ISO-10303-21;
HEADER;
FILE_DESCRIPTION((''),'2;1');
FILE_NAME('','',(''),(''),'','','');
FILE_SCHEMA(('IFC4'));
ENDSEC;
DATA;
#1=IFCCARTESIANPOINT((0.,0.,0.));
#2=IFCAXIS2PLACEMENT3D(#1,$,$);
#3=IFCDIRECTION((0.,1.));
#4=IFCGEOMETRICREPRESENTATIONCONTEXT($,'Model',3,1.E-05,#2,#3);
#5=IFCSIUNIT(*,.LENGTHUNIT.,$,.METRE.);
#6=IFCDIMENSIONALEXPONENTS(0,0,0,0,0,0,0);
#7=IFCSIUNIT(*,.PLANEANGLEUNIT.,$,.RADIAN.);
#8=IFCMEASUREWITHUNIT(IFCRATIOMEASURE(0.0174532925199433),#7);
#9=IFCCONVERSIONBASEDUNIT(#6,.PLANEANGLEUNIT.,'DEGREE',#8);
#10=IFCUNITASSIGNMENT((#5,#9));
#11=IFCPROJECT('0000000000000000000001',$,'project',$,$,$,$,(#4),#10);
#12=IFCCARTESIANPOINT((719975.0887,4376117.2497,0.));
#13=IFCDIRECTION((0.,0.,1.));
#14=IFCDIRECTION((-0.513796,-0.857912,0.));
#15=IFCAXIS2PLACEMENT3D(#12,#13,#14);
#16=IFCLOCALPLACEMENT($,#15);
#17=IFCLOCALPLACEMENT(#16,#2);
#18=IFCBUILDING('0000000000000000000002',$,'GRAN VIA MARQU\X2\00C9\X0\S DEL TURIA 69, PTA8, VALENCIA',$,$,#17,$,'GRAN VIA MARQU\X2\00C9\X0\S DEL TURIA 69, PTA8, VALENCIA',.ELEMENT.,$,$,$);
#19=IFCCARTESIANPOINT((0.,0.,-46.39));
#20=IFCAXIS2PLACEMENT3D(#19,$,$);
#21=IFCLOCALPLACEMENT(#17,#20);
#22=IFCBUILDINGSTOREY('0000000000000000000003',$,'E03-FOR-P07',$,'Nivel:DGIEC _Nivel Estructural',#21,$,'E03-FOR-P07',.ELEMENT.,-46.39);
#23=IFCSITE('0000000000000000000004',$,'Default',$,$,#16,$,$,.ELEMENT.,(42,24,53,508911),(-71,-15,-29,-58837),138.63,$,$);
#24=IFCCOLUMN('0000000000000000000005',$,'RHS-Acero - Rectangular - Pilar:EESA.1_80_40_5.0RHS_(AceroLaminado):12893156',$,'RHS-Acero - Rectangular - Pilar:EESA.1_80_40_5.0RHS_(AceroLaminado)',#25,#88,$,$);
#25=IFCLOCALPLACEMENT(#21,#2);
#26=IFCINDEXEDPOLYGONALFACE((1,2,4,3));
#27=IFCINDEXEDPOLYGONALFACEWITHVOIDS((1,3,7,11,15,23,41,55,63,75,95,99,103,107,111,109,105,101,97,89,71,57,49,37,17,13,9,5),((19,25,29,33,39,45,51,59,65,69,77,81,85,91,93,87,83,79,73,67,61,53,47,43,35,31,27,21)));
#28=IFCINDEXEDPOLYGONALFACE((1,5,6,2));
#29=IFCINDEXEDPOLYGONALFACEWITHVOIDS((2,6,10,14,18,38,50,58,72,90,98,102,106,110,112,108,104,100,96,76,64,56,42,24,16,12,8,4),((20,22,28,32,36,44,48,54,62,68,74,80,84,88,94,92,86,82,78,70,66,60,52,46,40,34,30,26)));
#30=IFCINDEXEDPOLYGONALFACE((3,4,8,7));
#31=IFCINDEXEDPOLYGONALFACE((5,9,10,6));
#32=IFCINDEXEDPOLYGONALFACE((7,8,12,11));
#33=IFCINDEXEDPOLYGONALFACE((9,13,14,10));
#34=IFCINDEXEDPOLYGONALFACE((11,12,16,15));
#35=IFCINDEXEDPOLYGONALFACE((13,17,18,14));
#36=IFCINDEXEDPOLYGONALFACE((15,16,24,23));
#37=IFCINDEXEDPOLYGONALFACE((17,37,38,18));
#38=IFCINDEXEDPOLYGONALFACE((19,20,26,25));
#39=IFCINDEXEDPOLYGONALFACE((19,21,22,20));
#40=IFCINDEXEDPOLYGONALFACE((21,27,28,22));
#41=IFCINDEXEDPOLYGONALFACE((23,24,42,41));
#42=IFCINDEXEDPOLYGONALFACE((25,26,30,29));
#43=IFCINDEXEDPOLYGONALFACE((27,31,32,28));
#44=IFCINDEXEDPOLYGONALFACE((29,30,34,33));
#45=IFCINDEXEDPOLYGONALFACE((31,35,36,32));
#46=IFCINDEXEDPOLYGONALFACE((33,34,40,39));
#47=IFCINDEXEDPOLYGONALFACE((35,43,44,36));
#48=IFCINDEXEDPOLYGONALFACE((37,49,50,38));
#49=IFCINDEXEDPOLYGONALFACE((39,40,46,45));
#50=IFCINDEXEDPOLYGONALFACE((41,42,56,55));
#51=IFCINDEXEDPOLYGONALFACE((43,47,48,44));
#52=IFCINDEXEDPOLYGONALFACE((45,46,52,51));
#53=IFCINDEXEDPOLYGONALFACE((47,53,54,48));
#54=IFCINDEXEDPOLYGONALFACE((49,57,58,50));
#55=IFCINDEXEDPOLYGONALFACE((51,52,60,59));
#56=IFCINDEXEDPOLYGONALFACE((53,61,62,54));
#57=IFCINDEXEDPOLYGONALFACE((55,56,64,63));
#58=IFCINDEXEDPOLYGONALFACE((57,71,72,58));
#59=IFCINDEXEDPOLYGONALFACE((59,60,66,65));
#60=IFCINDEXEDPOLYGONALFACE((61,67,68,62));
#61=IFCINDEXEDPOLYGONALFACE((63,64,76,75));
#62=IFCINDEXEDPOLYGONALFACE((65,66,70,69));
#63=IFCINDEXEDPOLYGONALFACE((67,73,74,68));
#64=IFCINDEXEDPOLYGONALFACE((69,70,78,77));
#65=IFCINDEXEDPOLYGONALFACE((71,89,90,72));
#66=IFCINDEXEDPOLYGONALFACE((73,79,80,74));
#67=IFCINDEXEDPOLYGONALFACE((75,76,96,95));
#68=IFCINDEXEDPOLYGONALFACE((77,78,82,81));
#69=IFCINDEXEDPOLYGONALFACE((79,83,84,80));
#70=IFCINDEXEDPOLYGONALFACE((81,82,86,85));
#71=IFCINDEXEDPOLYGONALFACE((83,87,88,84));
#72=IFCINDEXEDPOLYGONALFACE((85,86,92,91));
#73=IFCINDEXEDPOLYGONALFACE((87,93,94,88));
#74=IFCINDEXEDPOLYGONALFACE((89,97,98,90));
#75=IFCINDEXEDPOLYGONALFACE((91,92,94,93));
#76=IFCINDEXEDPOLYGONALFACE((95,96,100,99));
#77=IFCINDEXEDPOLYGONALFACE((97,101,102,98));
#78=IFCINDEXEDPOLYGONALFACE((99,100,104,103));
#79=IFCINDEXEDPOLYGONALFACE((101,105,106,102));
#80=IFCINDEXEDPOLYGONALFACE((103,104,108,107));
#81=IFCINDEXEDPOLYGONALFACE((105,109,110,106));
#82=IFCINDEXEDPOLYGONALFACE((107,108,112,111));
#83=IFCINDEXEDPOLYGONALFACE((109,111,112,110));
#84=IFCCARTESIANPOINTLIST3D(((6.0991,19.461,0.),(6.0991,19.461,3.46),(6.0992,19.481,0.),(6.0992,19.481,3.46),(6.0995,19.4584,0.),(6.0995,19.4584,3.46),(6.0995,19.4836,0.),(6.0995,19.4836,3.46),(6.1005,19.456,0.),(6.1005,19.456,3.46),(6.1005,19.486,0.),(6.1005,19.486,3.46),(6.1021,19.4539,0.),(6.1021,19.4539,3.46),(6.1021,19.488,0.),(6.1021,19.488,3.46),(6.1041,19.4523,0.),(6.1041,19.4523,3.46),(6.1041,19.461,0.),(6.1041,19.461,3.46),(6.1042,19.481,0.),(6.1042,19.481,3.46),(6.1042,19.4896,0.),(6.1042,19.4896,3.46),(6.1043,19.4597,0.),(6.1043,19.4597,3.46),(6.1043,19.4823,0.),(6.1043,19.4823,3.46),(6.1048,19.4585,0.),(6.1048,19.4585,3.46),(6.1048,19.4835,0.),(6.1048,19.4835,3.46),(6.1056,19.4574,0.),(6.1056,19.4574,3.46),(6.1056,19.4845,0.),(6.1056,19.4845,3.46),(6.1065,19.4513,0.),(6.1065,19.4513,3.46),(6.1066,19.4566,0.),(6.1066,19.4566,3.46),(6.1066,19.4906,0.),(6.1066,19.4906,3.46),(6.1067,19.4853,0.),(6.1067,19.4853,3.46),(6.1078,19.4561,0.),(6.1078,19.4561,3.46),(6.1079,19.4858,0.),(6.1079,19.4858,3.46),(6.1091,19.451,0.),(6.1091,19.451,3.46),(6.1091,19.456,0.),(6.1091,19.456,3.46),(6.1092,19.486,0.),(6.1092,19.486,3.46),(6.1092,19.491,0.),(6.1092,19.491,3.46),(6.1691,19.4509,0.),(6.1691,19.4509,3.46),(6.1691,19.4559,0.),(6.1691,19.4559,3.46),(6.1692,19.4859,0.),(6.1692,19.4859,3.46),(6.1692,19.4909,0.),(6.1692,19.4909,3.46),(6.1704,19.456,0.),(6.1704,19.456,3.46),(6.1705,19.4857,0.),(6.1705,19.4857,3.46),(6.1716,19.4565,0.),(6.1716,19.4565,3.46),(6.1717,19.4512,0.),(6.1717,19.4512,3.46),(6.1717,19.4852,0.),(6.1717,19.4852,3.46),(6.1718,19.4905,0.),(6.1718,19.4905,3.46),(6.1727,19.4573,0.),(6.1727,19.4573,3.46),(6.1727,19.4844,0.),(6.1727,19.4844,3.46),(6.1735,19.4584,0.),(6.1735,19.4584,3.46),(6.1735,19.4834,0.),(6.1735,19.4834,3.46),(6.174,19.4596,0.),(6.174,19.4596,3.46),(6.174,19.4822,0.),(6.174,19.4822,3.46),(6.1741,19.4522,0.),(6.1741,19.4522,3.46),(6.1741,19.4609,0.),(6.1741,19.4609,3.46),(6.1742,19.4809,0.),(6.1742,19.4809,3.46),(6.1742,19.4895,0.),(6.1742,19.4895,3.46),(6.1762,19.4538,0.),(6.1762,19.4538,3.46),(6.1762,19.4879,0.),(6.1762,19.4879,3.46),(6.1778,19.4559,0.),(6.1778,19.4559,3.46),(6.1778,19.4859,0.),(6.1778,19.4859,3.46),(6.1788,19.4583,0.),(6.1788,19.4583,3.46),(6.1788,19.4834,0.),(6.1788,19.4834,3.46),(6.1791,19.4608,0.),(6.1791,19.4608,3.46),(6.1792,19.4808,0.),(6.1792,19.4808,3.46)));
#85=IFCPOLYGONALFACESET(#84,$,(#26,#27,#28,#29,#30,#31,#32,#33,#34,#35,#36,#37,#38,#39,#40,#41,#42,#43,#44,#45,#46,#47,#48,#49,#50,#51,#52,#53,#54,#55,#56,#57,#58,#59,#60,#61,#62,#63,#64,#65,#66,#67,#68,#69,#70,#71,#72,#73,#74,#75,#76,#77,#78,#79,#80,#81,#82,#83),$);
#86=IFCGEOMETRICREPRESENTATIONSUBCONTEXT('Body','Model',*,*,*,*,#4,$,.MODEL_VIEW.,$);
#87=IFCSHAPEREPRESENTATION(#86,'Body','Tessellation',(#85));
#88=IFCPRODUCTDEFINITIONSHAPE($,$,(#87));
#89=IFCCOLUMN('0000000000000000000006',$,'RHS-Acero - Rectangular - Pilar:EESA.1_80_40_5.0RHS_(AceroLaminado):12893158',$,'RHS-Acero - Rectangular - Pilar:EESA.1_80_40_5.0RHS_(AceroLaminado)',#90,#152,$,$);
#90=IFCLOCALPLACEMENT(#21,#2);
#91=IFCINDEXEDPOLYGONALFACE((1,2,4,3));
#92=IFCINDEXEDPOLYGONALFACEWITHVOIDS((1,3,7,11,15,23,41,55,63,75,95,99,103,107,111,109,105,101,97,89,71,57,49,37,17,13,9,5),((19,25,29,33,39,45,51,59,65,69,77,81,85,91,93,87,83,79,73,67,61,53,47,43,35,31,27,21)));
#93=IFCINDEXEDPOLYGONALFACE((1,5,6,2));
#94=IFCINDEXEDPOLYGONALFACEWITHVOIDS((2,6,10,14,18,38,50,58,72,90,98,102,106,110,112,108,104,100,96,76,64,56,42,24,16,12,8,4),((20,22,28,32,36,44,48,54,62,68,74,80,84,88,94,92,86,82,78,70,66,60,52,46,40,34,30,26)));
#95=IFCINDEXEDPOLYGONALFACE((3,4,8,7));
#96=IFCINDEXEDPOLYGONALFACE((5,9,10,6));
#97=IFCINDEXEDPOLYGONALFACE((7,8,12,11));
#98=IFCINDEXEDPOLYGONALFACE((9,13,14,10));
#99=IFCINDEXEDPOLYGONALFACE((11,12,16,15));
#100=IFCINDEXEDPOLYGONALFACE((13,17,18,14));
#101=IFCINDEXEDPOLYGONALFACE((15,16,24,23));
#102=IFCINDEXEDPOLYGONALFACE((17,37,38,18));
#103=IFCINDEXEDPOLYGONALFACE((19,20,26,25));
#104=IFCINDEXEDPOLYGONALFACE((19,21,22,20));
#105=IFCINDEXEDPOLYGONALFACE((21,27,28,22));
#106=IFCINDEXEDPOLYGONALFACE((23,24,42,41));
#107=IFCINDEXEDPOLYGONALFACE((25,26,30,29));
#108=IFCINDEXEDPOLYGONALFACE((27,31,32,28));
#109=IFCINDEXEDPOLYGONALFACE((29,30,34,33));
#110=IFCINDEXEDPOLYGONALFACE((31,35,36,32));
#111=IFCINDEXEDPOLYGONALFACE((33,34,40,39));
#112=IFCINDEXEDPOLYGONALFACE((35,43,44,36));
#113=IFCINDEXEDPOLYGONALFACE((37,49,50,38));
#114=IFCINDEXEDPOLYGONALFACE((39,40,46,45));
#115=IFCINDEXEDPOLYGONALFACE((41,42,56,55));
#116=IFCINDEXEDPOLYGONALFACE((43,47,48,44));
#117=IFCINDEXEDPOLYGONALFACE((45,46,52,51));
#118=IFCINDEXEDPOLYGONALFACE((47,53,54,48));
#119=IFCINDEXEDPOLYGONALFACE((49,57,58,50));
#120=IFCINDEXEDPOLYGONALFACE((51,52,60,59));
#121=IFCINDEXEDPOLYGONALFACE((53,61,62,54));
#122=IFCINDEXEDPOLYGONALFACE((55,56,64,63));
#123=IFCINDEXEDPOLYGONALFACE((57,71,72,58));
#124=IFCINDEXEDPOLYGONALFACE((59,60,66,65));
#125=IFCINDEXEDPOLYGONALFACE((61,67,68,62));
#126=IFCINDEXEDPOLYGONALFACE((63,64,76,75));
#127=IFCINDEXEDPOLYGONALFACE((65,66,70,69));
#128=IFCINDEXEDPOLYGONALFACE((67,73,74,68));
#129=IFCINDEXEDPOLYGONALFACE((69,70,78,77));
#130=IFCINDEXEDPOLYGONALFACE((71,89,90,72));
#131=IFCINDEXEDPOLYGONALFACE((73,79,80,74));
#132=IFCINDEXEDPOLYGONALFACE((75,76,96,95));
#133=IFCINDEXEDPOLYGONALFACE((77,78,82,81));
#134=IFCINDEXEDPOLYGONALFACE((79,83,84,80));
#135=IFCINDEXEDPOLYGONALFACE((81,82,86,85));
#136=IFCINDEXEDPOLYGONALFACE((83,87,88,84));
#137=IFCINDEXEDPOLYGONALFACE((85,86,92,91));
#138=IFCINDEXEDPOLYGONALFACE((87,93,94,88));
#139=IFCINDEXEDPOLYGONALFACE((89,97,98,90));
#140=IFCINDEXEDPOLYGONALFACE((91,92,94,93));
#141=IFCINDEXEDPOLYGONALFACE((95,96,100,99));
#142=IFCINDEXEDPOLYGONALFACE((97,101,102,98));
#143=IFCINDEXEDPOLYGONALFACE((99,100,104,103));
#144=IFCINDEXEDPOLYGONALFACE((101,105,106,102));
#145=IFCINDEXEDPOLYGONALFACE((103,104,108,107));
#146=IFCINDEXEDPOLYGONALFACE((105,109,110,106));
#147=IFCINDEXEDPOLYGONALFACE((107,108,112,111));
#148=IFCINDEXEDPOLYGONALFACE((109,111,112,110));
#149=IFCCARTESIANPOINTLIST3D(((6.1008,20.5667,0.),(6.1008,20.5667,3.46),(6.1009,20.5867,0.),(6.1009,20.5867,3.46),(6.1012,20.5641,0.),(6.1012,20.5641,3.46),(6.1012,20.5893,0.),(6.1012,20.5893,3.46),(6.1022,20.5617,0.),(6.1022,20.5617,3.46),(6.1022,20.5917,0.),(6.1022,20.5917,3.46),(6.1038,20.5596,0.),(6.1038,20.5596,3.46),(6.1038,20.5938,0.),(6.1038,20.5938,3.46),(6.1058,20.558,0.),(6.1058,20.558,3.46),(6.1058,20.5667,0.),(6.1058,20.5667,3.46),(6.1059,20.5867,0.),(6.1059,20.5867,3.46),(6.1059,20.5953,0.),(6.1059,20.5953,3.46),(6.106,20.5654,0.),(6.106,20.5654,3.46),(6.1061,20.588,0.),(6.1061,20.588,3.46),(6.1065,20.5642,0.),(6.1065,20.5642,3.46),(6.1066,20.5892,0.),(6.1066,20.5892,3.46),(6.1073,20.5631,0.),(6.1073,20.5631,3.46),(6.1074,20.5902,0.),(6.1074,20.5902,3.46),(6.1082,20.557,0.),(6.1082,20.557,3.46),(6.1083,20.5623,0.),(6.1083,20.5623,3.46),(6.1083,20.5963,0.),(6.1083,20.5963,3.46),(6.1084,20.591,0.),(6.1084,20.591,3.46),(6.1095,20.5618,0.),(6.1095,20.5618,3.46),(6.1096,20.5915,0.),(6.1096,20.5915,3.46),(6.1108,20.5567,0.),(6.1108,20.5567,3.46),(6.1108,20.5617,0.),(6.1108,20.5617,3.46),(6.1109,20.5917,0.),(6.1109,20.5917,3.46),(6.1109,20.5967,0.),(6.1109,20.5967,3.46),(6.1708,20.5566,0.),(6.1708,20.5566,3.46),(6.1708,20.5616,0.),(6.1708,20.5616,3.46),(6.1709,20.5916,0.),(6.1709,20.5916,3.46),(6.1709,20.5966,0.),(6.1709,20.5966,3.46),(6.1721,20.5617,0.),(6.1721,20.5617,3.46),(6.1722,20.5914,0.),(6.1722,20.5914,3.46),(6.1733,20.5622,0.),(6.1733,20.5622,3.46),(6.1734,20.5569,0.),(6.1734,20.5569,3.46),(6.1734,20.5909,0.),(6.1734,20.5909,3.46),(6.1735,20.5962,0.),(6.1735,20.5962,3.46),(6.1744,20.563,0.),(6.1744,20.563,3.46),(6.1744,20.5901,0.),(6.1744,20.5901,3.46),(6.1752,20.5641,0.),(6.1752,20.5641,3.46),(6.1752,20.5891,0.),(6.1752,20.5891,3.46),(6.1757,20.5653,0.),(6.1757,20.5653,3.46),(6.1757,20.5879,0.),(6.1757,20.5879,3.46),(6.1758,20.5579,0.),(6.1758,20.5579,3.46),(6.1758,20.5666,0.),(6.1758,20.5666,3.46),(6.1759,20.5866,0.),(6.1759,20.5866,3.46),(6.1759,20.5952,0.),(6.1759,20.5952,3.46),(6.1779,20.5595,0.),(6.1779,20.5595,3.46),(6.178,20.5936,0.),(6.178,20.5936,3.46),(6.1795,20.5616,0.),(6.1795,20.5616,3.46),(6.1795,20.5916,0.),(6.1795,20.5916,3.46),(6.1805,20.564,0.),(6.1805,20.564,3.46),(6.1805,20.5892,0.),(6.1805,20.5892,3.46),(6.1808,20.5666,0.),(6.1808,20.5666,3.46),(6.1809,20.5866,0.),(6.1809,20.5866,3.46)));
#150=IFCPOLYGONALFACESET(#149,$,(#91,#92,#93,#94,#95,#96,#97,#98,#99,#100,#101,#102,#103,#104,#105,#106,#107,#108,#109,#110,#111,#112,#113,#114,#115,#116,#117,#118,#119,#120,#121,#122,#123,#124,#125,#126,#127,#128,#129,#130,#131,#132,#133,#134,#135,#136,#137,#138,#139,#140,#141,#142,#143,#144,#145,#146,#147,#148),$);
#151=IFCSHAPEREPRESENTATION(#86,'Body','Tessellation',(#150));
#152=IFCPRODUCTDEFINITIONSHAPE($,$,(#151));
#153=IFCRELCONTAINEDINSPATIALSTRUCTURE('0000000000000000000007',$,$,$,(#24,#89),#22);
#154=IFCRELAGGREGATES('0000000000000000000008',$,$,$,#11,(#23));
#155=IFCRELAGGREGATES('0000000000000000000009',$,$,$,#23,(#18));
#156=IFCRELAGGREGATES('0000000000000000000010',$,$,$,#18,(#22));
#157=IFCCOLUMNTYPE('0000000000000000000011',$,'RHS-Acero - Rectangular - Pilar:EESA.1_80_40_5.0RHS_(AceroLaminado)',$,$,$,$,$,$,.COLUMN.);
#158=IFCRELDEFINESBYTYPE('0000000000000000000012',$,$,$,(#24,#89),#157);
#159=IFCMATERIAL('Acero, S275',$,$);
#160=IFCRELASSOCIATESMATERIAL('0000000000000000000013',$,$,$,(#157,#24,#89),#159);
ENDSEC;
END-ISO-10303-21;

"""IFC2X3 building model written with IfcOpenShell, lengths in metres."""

from ifc_helpers import new_model, entity, si_unit, converted_unit, direction, frame, frame_2d, origin, place, context, subcontext, project, spatial, polyline, circle_curve, parameter, trimmed, segment, composite_curve, outline, extrude, source, transform, mapped, material, type_object, type_shapes, element, save


model = new_model("IFC2X3")

# Units and contexts
model_context = context("Model", 3, precision=1e-05, world=origin(), true_north=direction((0.0, 1.0)))
body_context = subcontext(model_context, "Body", "Model", "MODEL_VIEW")
ifc_project = project(units=[si_unit("LENGTHUNIT", "METRE"), converted_unit("PLANEANGLEUNIT", "DEGREE", entity("IfcRatioMeasure", 0.0174532925199433), si_unit("PLANEANGLEUNIT", "RADIAN"), dimensions=[0, 0, 0, 0, 0, 0, 0])], contexts=[model_context])

# Site, building, storey
site_placement = place(None, frame((719975.0887, 4376117.2497, 0.0), z_axis=(0.0, 0.0, 1.0), x_axis=(-0.513796, -0.857912, 0.0)))
site = spatial("IfcSite", under=ifc_project, at=site_placement, Name="Default", CompositionType="ELEMENT", RefLatitude=(42, 24, 53, 508911), RefLongitude=(-71, -15, -29, -58837), RefElevation=138.63)
building_placement = place(site_placement, origin())
building = spatial("IfcBuilding", under=site, at=building_placement, Name="GRAN VIA MARQUÉS DEL TURIA 69, PTA8, VALENCIA", LongName="GRAN VIA MARQUÉS DEL TURIA 69, PTA8, VALENCIA", CompositionType="ELEMENT")
storey_placement = place(building_placement, frame((0.0, 0.0, -46.39)))
storey = spatial("IfcBuildingStorey", under=building, at=storey_placement, Name="E03-FOR-P07", ObjectType="Nivel:DGIEC _Nivel Estructural", LongName="E03-FOR-P07", CompositionType="ELEMENT", Elevation=-46.39)

# Columns
ifc_material = material(Name="Acero, S275")
column_type_1 = type_object("IfcColumnType", Name="RHS-Acero - Rectangular - Pilar:EESA.1_80_40_5.0RHS_(AceroLaminado)", PredefinedType="COLUMN", material=ifc_material)
shared_shape_1 = source(origin(), body_context, "Body", "SweptSolid", [
    extrude(outline(composite_curve([segment(polyline([(-0.01, -0.04), (0.01, -0.04)]), True, "CONTINUOUS"), segment(trimmed(circle_curve(frame_2d((0.01, -0.03), x_axis=(-1.0, 0.0)), 0.01), [parameter(90.0)], [parameter(180.0)], True, "PARAMETER"), True, "CONTINUOUS"), segment(polyline([(0.02, -0.03), (0.02, 0.03)]), True, "CONTINUOUS"), segment(trimmed(circle_curve(frame_2d((0.01, 0.03), x_axis=(-1.0, 0.0)), 0.01), [parameter(180.0)], [parameter(270.0)], True, "PARAMETER"), True, "CONTINUOUS"), segment(polyline([(0.01, 0.04), (-0.01, 0.04)]), True, "CONTINUOUS"), segment(trimmed(circle_curve(frame_2d((-0.01, 0.03), x_axis=(-1.0, 0.0)), 0.01), [parameter(270.0)], [parameter(360.0)], True, "PARAMETER"), True, "CONTINUOUS"), segment(polyline([(-0.02, 0.03), (-0.02, -0.03)]), True, "CONTINUOUS"), segment(trimmed(circle_curve(frame_2d((-0.01, -0.03), x_axis=(-1.0, 0.0)), 0.01), [parameter(360.0)], [parameter(90.0)], True, "PARAMETER"), True, "CONTINUOUS")], self_intersect=False), holes=[composite_curve([segment(trimmed(circle_curve(frame_2d((-0.01, -0.03), x_axis=(-1.0, 0.0)), 0.005), [parameter(0.0)], [parameter(90.0)], True, "PARAMETER"), False, "CONTINUOUS"), segment(polyline([(-0.015, -0.03), (-0.015, 0.03)]), True, "CONTINUOUS"), segment(trimmed(circle_curve(frame_2d((-0.01, 0.03), x_axis=(-1.0, 0.0)), 0.005), [parameter(270.0)], [parameter(0.0)], True, "PARAMETER"), False, "CONTINUOUS"), segment(polyline([(-0.01, 0.035), (0.01, 0.035)]), True, "CONTINUOUS"), segment(trimmed(circle_curve(frame_2d((0.01, 0.03), x_axis=(-1.0, 0.0)), 0.005), [parameter(180.0)], [parameter(270.0)], True, "PARAMETER"), False, "CONTINUOUS"), segment(polyline([(0.015, 0.03), (0.015, -0.03)]), True, "CONTINUOUS"), segment(trimmed(circle_curve(frame_2d((0.01, -0.03), x_axis=(-1.0, 0.0)), 0.005), [parameter(90.0)], [parameter(180.0)], True, "PARAMETER"), False, "CONTINUOUS"), segment(polyline([(0.01, -0.035), (-0.01, -0.035)]), True, "CONTINUOUS")], self_intersect=False)]), frame((0.0, 0.0, -46.39), z_axis=(0.0, 0.0, 1.0), x_axis=(-1.0, 0.0, 0.0)), (0.0, 0.0, 1.0), 3.46),
])
type_shapes(column_type_1, [shared_shape_1])
for number, where, z_axis, x_axis, name in (
    (1, (6.1391, 19.4709, 46.39), (0.0, 0.0, 1.0), (0.001552, 0.999999, 0.0), "RHS-Acero - Rectangular - Pilar:EESA.1_80_40_5.0RHS_(AceroLaminado):12893156"),
    (2, (6.1409, 20.5766, 46.39), (0.0, 0.0, 1.0), (0.001552, 0.999999, 0.0), "RHS-Acero - Rectangular - Pilar:EESA.1_80_40_5.0RHS_(AceroLaminado):12893158"),
):
    element("IfcColumn", number, at=place(storey_placement, frame(where, z_axis=z_axis, x_axis=x_axis)), inside=storey, type_object=column_type_1, material=ifc_material, Name=name, ObjectType="RHS-Acero - Rectangular - Pilar:EESA.1_80_40_5.0RHS_(AceroLaminado)", context=body_context, shape_type="MappedRepresentation", body=[
        mapped(shared_shape_1, transform((0.0, 0.0, 0.0), scale=1.0)),
    ])

save(model, "model.ifc")
